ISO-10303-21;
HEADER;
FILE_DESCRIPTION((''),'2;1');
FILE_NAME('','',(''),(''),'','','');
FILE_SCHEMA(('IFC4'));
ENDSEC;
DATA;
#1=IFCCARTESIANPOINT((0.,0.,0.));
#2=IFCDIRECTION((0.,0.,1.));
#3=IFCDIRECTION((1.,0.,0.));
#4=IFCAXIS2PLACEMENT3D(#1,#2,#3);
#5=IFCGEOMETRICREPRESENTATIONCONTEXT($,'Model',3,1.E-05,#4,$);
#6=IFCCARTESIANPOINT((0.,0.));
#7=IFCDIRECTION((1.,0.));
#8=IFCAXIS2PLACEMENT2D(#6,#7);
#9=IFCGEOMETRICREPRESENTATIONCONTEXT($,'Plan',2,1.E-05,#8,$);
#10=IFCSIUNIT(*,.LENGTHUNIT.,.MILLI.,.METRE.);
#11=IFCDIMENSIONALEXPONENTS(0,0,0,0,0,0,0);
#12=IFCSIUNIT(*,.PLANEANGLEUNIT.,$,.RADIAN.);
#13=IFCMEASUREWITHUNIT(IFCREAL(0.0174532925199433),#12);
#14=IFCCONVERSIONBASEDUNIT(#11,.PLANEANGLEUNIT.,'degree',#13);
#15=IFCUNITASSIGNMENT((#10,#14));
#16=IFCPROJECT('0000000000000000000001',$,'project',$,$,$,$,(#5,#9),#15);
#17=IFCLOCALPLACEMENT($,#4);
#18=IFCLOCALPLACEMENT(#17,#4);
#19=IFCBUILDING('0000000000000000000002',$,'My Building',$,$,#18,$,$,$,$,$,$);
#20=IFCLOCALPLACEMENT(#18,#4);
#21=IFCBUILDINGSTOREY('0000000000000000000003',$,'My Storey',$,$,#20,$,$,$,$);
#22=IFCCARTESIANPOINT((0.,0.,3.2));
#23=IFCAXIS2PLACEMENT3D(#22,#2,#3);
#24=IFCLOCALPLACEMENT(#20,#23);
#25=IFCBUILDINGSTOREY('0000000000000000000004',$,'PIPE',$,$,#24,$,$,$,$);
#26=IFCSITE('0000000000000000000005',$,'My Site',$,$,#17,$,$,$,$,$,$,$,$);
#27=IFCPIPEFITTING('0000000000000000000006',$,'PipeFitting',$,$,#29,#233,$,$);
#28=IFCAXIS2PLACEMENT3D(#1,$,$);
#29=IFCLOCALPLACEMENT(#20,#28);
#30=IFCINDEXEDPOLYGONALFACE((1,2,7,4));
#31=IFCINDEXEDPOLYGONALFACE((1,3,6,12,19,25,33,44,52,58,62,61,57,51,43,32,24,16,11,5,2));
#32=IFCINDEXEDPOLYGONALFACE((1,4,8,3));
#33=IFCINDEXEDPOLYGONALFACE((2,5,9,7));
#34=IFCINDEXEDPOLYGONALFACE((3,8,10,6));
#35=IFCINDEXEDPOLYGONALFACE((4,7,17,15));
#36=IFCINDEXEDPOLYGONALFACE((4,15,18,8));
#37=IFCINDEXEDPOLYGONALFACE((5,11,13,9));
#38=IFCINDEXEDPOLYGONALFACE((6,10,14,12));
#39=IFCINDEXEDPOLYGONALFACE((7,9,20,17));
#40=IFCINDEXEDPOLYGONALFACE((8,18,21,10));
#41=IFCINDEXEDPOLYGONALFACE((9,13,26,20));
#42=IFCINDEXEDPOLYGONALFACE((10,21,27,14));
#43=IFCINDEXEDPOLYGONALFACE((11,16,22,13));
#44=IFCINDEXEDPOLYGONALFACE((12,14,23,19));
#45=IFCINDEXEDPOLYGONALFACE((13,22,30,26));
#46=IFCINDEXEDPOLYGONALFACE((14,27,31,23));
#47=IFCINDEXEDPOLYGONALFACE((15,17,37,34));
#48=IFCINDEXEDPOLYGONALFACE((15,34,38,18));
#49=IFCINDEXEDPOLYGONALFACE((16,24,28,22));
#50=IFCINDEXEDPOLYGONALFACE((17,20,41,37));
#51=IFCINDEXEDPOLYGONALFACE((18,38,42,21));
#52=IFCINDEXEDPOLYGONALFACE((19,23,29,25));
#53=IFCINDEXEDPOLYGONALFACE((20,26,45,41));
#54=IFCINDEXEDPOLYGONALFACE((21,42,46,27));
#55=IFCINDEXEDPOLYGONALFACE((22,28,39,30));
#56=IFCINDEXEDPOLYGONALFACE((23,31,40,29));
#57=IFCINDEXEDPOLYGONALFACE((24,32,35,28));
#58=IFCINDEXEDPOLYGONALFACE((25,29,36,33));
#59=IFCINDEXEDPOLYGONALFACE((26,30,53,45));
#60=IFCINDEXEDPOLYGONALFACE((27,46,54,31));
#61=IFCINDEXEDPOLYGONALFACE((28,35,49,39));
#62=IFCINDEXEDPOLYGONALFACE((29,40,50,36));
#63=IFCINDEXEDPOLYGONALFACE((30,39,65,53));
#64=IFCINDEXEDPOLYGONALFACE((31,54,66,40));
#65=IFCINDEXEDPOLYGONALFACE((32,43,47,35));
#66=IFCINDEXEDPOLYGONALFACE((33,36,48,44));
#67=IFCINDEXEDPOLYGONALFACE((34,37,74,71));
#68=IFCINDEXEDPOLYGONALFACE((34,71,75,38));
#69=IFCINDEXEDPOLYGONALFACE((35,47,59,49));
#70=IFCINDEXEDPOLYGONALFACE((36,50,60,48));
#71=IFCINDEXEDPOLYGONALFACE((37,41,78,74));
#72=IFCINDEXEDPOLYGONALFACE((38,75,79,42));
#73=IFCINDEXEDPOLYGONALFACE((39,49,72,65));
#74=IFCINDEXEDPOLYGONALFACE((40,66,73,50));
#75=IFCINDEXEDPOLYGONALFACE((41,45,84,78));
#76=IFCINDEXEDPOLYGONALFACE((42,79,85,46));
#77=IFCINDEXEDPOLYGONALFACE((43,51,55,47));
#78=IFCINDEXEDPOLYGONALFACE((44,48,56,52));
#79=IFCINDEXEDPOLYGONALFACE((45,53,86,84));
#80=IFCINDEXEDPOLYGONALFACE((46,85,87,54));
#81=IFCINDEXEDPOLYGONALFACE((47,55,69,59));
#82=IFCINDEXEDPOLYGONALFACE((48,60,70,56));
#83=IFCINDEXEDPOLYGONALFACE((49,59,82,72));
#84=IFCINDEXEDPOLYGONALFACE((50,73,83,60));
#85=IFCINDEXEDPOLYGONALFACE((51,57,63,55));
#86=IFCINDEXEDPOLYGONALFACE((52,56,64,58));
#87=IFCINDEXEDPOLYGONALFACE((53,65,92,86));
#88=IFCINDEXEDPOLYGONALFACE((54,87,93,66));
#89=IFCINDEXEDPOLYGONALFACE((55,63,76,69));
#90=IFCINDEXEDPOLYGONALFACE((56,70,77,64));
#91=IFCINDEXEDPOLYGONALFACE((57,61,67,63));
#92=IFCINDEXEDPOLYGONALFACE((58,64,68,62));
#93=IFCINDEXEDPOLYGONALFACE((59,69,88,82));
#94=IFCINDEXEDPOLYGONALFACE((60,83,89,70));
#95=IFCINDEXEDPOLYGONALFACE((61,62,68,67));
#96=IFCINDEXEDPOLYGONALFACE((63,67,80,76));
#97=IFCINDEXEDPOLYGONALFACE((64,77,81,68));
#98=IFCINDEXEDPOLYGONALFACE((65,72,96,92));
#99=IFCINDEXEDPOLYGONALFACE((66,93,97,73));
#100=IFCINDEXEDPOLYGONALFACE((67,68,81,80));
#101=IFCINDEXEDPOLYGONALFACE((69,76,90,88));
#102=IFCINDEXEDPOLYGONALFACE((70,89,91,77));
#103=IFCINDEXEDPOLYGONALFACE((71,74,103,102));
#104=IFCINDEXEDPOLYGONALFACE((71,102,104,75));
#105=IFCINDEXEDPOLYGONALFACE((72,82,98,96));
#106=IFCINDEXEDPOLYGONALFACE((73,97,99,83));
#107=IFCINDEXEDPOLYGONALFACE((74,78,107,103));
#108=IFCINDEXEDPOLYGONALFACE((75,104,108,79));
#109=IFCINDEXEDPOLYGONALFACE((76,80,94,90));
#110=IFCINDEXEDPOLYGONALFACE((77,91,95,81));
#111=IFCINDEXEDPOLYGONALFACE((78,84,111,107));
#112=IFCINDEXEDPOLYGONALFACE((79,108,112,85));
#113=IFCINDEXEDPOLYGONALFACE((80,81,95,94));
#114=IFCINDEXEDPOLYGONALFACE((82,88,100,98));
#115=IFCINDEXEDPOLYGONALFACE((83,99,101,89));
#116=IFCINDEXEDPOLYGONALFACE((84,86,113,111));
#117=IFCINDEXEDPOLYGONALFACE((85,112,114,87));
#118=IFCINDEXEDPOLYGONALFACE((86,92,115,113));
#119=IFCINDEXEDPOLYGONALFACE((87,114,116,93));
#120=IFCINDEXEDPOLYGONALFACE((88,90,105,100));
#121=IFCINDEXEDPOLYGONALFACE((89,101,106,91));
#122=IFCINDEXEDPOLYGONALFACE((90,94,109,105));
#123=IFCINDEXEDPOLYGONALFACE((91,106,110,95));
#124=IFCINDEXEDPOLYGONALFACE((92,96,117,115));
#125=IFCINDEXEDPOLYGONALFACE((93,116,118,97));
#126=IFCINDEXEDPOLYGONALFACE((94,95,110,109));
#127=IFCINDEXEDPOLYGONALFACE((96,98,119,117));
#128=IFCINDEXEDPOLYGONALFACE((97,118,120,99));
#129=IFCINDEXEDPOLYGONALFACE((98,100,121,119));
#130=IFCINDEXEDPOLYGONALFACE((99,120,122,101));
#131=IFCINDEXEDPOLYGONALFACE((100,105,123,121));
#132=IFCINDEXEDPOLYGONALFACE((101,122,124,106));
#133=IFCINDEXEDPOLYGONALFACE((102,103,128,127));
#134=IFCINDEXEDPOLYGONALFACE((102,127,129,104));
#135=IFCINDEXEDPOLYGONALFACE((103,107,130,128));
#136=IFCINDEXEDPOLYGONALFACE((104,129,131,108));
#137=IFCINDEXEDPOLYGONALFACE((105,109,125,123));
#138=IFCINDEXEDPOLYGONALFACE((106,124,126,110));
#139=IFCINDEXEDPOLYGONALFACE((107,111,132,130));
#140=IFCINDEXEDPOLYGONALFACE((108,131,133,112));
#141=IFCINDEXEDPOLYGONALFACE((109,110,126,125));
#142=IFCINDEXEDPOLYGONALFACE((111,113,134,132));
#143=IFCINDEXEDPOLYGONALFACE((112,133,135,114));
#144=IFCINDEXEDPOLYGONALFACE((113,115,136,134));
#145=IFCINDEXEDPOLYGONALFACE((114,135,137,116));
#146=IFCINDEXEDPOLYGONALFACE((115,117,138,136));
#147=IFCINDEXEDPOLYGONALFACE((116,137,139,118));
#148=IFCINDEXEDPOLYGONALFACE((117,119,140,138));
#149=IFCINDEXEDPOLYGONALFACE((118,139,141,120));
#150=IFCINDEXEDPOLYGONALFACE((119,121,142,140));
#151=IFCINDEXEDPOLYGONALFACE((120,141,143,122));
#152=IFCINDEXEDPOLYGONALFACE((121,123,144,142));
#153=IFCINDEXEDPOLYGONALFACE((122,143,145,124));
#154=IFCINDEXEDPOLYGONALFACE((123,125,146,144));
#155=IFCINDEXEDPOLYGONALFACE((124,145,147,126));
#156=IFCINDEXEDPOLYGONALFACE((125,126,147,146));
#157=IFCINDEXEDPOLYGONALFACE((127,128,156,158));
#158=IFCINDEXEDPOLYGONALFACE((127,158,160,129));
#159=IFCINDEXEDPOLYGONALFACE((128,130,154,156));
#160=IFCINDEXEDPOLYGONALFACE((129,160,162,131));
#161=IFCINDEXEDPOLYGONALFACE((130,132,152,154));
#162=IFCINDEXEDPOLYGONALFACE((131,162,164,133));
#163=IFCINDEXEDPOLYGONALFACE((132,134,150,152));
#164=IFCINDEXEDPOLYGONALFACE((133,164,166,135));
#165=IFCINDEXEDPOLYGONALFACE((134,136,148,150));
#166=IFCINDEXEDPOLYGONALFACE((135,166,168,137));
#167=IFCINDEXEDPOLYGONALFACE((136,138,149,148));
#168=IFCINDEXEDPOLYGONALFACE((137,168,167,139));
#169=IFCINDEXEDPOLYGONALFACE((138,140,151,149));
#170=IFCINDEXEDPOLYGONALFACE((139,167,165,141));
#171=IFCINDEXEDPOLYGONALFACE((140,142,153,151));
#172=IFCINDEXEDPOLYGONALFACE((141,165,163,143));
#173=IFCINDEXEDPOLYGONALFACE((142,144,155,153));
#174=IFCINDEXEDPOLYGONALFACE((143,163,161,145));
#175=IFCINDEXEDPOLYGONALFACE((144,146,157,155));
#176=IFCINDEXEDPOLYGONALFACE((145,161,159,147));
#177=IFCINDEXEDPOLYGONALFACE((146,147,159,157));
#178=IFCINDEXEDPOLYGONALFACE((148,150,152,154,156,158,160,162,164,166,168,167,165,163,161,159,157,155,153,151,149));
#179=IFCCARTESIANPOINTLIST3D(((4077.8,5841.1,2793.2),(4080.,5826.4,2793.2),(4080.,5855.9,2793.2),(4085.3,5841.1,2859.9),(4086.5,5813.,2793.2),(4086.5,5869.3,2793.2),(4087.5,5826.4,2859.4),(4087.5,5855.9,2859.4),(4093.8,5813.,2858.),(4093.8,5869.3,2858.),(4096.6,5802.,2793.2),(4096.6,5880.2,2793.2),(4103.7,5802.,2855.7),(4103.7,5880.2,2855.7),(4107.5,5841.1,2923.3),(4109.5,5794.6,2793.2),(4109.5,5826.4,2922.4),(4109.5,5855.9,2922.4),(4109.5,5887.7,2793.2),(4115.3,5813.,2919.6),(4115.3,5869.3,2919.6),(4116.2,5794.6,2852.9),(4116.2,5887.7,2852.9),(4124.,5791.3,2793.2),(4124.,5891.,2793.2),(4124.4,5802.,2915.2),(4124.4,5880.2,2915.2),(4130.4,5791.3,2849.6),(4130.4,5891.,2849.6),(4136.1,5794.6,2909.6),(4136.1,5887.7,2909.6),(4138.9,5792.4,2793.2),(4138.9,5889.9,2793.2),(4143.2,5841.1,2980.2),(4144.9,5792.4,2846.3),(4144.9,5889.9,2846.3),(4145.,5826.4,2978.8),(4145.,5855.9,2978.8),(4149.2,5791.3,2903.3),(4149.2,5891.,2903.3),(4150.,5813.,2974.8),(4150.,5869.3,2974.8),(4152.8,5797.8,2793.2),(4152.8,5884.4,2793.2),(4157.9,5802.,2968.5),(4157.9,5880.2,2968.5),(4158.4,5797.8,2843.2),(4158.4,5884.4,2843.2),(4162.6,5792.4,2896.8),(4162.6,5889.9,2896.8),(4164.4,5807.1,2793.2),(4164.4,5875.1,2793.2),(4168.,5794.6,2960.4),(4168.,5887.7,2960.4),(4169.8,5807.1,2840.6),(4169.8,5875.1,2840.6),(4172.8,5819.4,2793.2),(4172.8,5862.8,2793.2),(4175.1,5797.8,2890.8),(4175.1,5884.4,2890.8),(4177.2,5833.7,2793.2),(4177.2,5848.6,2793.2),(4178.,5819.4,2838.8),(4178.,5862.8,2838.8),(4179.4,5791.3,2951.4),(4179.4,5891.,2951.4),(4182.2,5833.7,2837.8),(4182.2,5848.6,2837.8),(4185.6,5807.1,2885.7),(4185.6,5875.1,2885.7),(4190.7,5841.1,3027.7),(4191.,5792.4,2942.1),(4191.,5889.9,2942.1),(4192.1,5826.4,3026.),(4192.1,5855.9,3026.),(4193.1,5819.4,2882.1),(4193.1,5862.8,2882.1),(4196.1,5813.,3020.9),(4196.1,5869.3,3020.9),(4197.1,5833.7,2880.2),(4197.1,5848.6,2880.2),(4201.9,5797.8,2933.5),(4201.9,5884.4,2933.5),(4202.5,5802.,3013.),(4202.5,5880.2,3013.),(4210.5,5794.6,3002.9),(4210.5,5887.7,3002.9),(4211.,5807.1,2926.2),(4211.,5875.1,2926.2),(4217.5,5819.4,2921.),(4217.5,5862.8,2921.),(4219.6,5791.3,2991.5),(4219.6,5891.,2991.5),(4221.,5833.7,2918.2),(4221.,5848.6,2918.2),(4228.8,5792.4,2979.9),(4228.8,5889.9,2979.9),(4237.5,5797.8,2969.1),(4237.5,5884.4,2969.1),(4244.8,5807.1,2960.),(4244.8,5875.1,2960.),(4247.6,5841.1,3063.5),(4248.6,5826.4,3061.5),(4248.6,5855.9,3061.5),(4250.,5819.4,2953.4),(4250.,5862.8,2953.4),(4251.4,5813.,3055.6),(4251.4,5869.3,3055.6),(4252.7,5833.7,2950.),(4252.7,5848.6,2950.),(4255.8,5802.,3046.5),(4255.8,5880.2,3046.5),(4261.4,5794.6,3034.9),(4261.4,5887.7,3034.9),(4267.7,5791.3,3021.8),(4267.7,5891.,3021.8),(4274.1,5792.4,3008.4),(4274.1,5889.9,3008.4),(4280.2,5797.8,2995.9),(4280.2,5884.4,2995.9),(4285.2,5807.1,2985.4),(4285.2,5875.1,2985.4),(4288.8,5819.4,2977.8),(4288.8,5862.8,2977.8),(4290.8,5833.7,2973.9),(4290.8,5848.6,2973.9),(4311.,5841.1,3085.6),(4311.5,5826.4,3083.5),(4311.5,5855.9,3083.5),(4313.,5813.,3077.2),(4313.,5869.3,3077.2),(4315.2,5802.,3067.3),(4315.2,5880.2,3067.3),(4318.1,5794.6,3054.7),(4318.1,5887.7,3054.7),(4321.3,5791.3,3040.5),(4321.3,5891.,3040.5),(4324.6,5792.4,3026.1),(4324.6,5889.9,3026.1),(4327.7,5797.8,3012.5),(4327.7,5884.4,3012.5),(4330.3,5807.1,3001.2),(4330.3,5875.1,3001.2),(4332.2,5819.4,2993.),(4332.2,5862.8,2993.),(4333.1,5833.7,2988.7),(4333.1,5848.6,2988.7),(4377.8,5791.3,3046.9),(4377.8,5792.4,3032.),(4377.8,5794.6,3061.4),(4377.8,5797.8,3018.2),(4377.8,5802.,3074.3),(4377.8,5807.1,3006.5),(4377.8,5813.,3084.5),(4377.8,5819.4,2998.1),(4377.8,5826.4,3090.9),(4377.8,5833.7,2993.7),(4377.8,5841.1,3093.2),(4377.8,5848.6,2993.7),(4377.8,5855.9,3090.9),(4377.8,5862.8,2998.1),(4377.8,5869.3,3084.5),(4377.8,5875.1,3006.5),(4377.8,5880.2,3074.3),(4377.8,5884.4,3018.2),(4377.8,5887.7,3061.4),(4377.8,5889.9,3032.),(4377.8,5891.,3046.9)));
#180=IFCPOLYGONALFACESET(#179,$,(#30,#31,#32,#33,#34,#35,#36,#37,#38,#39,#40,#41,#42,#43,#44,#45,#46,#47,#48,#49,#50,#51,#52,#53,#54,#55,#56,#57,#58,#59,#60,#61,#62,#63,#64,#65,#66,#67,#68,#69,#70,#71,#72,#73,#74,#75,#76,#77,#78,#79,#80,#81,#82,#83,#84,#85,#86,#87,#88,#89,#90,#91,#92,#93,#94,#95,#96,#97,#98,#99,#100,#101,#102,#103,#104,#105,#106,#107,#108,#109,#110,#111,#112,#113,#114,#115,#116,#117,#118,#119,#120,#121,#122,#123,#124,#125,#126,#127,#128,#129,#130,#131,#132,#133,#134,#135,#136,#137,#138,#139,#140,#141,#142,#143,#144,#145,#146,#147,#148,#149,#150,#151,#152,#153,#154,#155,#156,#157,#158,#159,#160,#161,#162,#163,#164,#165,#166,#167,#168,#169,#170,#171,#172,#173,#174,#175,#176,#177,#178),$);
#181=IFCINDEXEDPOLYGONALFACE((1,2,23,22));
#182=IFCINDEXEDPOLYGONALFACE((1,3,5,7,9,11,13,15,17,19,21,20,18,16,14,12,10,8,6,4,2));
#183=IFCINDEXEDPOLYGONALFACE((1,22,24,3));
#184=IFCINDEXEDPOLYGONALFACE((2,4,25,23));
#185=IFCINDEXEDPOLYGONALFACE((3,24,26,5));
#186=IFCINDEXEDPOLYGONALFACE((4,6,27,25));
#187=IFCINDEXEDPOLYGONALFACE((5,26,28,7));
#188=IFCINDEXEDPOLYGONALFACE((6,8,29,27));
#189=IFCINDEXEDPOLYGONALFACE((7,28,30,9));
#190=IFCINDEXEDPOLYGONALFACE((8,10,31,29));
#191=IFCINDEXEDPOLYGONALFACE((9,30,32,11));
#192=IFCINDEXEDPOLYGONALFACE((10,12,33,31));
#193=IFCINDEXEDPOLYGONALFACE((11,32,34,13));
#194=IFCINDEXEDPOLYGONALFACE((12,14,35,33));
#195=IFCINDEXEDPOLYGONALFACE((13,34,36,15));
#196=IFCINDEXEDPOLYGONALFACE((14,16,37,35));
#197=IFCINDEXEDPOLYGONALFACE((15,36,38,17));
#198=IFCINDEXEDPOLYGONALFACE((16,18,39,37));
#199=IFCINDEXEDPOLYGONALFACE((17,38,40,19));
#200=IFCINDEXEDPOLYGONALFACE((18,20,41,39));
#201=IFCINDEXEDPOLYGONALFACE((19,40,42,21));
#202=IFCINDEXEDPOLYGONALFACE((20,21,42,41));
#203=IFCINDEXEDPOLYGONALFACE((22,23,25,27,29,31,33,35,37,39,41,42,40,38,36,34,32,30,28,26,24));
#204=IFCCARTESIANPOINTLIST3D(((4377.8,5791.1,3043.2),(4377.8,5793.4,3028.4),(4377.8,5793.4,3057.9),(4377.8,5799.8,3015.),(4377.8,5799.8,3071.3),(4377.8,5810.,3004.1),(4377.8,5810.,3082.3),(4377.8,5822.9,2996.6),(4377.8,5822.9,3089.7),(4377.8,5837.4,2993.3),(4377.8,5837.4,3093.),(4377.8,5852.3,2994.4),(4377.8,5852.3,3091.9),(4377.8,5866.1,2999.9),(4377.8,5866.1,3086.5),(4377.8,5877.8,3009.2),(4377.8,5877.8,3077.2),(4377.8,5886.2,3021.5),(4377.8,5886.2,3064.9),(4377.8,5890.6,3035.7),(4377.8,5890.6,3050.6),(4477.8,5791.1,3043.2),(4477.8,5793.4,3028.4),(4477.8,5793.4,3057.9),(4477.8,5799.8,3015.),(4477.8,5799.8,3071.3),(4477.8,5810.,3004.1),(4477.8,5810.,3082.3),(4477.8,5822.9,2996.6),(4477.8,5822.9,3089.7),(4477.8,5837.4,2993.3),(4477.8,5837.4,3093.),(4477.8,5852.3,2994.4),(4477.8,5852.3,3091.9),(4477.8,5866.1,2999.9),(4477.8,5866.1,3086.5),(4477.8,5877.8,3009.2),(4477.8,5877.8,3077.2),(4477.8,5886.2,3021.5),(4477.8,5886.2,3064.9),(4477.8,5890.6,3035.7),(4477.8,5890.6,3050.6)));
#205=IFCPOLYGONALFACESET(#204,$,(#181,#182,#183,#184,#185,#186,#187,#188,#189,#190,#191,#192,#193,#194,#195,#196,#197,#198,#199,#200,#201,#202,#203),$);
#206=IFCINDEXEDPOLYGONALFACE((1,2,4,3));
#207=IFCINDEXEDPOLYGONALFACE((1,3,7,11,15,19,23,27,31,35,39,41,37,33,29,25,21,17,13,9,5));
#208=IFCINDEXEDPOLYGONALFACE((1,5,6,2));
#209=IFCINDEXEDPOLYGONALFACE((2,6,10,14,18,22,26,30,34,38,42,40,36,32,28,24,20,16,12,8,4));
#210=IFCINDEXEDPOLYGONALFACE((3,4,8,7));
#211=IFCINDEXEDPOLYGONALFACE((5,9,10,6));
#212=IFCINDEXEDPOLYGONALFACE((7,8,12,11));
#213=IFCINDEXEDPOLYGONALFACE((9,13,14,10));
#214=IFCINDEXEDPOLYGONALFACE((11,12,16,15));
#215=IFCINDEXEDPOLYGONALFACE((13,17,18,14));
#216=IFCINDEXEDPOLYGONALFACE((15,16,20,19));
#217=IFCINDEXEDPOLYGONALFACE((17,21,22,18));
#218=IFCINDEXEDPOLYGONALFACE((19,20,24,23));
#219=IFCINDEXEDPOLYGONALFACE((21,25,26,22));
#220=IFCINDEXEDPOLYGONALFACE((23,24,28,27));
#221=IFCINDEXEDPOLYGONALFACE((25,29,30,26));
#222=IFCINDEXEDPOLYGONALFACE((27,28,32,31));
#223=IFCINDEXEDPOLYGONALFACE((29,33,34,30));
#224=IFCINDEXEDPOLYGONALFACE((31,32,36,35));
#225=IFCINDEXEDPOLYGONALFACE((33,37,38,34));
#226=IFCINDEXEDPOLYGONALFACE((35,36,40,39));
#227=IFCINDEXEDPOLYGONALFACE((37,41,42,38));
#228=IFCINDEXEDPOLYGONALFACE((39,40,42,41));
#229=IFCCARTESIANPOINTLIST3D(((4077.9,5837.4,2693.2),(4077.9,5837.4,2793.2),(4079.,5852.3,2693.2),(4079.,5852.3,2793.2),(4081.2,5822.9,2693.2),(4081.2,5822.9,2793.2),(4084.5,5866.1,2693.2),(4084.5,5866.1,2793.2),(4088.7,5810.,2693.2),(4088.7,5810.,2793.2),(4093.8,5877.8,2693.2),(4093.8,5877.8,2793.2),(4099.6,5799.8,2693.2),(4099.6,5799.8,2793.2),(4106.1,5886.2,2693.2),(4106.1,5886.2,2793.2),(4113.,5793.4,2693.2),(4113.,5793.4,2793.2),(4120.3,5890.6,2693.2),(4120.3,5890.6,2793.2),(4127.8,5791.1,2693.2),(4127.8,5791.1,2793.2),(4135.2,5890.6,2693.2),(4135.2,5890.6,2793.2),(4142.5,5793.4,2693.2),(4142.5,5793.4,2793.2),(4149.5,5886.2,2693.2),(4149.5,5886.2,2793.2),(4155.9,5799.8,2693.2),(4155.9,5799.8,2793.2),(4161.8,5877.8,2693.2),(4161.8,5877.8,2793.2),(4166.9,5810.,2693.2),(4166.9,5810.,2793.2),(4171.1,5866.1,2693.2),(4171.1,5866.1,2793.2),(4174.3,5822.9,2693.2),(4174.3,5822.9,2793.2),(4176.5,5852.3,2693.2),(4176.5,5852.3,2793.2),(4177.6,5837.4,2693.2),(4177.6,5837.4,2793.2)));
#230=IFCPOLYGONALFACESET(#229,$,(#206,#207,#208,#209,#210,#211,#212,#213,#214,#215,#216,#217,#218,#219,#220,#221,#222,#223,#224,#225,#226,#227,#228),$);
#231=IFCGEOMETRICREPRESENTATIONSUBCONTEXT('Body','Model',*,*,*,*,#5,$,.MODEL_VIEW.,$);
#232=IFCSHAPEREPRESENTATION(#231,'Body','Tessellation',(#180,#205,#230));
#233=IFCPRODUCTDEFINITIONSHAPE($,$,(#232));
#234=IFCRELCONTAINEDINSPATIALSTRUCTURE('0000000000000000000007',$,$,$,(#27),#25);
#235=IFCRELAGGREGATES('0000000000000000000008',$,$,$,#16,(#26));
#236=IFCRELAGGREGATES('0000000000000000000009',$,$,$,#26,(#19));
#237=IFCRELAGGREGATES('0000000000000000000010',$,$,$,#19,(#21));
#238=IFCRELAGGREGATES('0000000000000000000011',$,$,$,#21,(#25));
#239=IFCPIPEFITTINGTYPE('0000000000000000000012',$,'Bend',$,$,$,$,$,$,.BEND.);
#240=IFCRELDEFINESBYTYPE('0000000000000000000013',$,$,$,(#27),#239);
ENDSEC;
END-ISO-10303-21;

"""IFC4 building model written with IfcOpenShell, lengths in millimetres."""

from ifc_helpers import new_model, entity, si_unit, converted_unit, frame, origin_with_axes, origin_2d_with_axis, place, context, subcontext, project, spatial, circle, extrude, source, transform, mapped, type_object, type_shapes, element, save


model = new_model("IFC4")

# Units and contexts
model_context = context("Model", 3, precision=1e-05, world=origin_with_axes())
plan_context = context("Plan", 2, precision=1e-05, world=origin_2d_with_axis())
body_context = subcontext(model_context, "Body", "Model", "MODEL_VIEW")
ifc_project = project(units=[si_unit("LENGTHUNIT", "METRE", prefix="MILLI"), converted_unit("PLANEANGLEUNIT", "degree", entity("IfcReal", 0.0174532925199433), si_unit("PLANEANGLEUNIT", "RADIAN"), dimensions=[0, 0, 0, 0, 0, 0, 0])], contexts=[model_context, plan_context])

# Site, building, storeys
site_placement = place(None, origin_with_axes())
site = spatial("IfcSite", under=ifc_project, at=site_placement, Name="My Site")
building_placement = place(site_placement, origin_with_axes())
building = spatial("IfcBuilding", under=site, at=building_placement, Name="My Building")
storey_1_placement = place(building_placement, origin_with_axes())
storey_1 = spatial("IfcBuildingStorey", under=building, at=storey_1_placement, Name="My Storey")
storey_2_placement = place(storey_1_placement, frame((0.0, 0.0, 3.2), z_axis=(0.0, 0.0, 1.0), x_axis=(1.0, 0.0, 0.0)))
storey_2 = spatial("IfcBuildingStorey", under=storey_1, at=storey_2_placement, Name="PIPE")

# Pipe fitting
pipe_fitting_type = type_object("IfcPipeFittingType", Name="Bend", PredefinedType="BEND")
shared_shape = source(origin_with_axes(), body_context, "Body", "SolidModel", [
    entity("IfcSweptDiskSolid", entity("IfcIndexedPolyCurve", entity("IfcCartesianPointList3D", [[0.0, 0.0, 100.0], [0.0, -73.2, 276.8], [0.0, -250.0, 350.0]]), [entity("IfcArcIndex", [1, 2, 3])]), 50.0),
    extrude(circle(Radius=50.0), origin_with_axes(), (0.0, 0.0, 1.0), 100.0),
    extrude(circle(Radius=50.0), frame((0.0, -250.0, 350.0), z_axis=(0.0, -1.0, 0.0), x_axis=(1.0, 0.0, 0.0)), (0.0, 0.0, 1.0), 100.0),
])
type_shapes(pipe_fitting_type, [shared_shape])
for number, where, z_axis, x_axis, name in (
    (1, (4477.8, 5841.1, 3040.0), (-1.0, 0.0, 0.0), (0.0, -1.0, 0.0), "PipeFitting"),
):
    element("IfcPipeFitting", number, at=place(storey_2_placement, frame(where, z_axis=z_axis, x_axis=x_axis)), inside=storey_2, type_object=pipe_fitting_type, Name=name, context=body_context, shape_type="MappedRepresentation", body=[
        mapped(shared_shape, transform((0.0, 0.0, 0.0), x_axis=(1.0, 0.0, 0.0), y_axis=(0.0, 1.0, 0.0), z_axis=(0.0, 0.0, 1.0), scale=1.0)),
    ])

save(model, "model.ifc")
